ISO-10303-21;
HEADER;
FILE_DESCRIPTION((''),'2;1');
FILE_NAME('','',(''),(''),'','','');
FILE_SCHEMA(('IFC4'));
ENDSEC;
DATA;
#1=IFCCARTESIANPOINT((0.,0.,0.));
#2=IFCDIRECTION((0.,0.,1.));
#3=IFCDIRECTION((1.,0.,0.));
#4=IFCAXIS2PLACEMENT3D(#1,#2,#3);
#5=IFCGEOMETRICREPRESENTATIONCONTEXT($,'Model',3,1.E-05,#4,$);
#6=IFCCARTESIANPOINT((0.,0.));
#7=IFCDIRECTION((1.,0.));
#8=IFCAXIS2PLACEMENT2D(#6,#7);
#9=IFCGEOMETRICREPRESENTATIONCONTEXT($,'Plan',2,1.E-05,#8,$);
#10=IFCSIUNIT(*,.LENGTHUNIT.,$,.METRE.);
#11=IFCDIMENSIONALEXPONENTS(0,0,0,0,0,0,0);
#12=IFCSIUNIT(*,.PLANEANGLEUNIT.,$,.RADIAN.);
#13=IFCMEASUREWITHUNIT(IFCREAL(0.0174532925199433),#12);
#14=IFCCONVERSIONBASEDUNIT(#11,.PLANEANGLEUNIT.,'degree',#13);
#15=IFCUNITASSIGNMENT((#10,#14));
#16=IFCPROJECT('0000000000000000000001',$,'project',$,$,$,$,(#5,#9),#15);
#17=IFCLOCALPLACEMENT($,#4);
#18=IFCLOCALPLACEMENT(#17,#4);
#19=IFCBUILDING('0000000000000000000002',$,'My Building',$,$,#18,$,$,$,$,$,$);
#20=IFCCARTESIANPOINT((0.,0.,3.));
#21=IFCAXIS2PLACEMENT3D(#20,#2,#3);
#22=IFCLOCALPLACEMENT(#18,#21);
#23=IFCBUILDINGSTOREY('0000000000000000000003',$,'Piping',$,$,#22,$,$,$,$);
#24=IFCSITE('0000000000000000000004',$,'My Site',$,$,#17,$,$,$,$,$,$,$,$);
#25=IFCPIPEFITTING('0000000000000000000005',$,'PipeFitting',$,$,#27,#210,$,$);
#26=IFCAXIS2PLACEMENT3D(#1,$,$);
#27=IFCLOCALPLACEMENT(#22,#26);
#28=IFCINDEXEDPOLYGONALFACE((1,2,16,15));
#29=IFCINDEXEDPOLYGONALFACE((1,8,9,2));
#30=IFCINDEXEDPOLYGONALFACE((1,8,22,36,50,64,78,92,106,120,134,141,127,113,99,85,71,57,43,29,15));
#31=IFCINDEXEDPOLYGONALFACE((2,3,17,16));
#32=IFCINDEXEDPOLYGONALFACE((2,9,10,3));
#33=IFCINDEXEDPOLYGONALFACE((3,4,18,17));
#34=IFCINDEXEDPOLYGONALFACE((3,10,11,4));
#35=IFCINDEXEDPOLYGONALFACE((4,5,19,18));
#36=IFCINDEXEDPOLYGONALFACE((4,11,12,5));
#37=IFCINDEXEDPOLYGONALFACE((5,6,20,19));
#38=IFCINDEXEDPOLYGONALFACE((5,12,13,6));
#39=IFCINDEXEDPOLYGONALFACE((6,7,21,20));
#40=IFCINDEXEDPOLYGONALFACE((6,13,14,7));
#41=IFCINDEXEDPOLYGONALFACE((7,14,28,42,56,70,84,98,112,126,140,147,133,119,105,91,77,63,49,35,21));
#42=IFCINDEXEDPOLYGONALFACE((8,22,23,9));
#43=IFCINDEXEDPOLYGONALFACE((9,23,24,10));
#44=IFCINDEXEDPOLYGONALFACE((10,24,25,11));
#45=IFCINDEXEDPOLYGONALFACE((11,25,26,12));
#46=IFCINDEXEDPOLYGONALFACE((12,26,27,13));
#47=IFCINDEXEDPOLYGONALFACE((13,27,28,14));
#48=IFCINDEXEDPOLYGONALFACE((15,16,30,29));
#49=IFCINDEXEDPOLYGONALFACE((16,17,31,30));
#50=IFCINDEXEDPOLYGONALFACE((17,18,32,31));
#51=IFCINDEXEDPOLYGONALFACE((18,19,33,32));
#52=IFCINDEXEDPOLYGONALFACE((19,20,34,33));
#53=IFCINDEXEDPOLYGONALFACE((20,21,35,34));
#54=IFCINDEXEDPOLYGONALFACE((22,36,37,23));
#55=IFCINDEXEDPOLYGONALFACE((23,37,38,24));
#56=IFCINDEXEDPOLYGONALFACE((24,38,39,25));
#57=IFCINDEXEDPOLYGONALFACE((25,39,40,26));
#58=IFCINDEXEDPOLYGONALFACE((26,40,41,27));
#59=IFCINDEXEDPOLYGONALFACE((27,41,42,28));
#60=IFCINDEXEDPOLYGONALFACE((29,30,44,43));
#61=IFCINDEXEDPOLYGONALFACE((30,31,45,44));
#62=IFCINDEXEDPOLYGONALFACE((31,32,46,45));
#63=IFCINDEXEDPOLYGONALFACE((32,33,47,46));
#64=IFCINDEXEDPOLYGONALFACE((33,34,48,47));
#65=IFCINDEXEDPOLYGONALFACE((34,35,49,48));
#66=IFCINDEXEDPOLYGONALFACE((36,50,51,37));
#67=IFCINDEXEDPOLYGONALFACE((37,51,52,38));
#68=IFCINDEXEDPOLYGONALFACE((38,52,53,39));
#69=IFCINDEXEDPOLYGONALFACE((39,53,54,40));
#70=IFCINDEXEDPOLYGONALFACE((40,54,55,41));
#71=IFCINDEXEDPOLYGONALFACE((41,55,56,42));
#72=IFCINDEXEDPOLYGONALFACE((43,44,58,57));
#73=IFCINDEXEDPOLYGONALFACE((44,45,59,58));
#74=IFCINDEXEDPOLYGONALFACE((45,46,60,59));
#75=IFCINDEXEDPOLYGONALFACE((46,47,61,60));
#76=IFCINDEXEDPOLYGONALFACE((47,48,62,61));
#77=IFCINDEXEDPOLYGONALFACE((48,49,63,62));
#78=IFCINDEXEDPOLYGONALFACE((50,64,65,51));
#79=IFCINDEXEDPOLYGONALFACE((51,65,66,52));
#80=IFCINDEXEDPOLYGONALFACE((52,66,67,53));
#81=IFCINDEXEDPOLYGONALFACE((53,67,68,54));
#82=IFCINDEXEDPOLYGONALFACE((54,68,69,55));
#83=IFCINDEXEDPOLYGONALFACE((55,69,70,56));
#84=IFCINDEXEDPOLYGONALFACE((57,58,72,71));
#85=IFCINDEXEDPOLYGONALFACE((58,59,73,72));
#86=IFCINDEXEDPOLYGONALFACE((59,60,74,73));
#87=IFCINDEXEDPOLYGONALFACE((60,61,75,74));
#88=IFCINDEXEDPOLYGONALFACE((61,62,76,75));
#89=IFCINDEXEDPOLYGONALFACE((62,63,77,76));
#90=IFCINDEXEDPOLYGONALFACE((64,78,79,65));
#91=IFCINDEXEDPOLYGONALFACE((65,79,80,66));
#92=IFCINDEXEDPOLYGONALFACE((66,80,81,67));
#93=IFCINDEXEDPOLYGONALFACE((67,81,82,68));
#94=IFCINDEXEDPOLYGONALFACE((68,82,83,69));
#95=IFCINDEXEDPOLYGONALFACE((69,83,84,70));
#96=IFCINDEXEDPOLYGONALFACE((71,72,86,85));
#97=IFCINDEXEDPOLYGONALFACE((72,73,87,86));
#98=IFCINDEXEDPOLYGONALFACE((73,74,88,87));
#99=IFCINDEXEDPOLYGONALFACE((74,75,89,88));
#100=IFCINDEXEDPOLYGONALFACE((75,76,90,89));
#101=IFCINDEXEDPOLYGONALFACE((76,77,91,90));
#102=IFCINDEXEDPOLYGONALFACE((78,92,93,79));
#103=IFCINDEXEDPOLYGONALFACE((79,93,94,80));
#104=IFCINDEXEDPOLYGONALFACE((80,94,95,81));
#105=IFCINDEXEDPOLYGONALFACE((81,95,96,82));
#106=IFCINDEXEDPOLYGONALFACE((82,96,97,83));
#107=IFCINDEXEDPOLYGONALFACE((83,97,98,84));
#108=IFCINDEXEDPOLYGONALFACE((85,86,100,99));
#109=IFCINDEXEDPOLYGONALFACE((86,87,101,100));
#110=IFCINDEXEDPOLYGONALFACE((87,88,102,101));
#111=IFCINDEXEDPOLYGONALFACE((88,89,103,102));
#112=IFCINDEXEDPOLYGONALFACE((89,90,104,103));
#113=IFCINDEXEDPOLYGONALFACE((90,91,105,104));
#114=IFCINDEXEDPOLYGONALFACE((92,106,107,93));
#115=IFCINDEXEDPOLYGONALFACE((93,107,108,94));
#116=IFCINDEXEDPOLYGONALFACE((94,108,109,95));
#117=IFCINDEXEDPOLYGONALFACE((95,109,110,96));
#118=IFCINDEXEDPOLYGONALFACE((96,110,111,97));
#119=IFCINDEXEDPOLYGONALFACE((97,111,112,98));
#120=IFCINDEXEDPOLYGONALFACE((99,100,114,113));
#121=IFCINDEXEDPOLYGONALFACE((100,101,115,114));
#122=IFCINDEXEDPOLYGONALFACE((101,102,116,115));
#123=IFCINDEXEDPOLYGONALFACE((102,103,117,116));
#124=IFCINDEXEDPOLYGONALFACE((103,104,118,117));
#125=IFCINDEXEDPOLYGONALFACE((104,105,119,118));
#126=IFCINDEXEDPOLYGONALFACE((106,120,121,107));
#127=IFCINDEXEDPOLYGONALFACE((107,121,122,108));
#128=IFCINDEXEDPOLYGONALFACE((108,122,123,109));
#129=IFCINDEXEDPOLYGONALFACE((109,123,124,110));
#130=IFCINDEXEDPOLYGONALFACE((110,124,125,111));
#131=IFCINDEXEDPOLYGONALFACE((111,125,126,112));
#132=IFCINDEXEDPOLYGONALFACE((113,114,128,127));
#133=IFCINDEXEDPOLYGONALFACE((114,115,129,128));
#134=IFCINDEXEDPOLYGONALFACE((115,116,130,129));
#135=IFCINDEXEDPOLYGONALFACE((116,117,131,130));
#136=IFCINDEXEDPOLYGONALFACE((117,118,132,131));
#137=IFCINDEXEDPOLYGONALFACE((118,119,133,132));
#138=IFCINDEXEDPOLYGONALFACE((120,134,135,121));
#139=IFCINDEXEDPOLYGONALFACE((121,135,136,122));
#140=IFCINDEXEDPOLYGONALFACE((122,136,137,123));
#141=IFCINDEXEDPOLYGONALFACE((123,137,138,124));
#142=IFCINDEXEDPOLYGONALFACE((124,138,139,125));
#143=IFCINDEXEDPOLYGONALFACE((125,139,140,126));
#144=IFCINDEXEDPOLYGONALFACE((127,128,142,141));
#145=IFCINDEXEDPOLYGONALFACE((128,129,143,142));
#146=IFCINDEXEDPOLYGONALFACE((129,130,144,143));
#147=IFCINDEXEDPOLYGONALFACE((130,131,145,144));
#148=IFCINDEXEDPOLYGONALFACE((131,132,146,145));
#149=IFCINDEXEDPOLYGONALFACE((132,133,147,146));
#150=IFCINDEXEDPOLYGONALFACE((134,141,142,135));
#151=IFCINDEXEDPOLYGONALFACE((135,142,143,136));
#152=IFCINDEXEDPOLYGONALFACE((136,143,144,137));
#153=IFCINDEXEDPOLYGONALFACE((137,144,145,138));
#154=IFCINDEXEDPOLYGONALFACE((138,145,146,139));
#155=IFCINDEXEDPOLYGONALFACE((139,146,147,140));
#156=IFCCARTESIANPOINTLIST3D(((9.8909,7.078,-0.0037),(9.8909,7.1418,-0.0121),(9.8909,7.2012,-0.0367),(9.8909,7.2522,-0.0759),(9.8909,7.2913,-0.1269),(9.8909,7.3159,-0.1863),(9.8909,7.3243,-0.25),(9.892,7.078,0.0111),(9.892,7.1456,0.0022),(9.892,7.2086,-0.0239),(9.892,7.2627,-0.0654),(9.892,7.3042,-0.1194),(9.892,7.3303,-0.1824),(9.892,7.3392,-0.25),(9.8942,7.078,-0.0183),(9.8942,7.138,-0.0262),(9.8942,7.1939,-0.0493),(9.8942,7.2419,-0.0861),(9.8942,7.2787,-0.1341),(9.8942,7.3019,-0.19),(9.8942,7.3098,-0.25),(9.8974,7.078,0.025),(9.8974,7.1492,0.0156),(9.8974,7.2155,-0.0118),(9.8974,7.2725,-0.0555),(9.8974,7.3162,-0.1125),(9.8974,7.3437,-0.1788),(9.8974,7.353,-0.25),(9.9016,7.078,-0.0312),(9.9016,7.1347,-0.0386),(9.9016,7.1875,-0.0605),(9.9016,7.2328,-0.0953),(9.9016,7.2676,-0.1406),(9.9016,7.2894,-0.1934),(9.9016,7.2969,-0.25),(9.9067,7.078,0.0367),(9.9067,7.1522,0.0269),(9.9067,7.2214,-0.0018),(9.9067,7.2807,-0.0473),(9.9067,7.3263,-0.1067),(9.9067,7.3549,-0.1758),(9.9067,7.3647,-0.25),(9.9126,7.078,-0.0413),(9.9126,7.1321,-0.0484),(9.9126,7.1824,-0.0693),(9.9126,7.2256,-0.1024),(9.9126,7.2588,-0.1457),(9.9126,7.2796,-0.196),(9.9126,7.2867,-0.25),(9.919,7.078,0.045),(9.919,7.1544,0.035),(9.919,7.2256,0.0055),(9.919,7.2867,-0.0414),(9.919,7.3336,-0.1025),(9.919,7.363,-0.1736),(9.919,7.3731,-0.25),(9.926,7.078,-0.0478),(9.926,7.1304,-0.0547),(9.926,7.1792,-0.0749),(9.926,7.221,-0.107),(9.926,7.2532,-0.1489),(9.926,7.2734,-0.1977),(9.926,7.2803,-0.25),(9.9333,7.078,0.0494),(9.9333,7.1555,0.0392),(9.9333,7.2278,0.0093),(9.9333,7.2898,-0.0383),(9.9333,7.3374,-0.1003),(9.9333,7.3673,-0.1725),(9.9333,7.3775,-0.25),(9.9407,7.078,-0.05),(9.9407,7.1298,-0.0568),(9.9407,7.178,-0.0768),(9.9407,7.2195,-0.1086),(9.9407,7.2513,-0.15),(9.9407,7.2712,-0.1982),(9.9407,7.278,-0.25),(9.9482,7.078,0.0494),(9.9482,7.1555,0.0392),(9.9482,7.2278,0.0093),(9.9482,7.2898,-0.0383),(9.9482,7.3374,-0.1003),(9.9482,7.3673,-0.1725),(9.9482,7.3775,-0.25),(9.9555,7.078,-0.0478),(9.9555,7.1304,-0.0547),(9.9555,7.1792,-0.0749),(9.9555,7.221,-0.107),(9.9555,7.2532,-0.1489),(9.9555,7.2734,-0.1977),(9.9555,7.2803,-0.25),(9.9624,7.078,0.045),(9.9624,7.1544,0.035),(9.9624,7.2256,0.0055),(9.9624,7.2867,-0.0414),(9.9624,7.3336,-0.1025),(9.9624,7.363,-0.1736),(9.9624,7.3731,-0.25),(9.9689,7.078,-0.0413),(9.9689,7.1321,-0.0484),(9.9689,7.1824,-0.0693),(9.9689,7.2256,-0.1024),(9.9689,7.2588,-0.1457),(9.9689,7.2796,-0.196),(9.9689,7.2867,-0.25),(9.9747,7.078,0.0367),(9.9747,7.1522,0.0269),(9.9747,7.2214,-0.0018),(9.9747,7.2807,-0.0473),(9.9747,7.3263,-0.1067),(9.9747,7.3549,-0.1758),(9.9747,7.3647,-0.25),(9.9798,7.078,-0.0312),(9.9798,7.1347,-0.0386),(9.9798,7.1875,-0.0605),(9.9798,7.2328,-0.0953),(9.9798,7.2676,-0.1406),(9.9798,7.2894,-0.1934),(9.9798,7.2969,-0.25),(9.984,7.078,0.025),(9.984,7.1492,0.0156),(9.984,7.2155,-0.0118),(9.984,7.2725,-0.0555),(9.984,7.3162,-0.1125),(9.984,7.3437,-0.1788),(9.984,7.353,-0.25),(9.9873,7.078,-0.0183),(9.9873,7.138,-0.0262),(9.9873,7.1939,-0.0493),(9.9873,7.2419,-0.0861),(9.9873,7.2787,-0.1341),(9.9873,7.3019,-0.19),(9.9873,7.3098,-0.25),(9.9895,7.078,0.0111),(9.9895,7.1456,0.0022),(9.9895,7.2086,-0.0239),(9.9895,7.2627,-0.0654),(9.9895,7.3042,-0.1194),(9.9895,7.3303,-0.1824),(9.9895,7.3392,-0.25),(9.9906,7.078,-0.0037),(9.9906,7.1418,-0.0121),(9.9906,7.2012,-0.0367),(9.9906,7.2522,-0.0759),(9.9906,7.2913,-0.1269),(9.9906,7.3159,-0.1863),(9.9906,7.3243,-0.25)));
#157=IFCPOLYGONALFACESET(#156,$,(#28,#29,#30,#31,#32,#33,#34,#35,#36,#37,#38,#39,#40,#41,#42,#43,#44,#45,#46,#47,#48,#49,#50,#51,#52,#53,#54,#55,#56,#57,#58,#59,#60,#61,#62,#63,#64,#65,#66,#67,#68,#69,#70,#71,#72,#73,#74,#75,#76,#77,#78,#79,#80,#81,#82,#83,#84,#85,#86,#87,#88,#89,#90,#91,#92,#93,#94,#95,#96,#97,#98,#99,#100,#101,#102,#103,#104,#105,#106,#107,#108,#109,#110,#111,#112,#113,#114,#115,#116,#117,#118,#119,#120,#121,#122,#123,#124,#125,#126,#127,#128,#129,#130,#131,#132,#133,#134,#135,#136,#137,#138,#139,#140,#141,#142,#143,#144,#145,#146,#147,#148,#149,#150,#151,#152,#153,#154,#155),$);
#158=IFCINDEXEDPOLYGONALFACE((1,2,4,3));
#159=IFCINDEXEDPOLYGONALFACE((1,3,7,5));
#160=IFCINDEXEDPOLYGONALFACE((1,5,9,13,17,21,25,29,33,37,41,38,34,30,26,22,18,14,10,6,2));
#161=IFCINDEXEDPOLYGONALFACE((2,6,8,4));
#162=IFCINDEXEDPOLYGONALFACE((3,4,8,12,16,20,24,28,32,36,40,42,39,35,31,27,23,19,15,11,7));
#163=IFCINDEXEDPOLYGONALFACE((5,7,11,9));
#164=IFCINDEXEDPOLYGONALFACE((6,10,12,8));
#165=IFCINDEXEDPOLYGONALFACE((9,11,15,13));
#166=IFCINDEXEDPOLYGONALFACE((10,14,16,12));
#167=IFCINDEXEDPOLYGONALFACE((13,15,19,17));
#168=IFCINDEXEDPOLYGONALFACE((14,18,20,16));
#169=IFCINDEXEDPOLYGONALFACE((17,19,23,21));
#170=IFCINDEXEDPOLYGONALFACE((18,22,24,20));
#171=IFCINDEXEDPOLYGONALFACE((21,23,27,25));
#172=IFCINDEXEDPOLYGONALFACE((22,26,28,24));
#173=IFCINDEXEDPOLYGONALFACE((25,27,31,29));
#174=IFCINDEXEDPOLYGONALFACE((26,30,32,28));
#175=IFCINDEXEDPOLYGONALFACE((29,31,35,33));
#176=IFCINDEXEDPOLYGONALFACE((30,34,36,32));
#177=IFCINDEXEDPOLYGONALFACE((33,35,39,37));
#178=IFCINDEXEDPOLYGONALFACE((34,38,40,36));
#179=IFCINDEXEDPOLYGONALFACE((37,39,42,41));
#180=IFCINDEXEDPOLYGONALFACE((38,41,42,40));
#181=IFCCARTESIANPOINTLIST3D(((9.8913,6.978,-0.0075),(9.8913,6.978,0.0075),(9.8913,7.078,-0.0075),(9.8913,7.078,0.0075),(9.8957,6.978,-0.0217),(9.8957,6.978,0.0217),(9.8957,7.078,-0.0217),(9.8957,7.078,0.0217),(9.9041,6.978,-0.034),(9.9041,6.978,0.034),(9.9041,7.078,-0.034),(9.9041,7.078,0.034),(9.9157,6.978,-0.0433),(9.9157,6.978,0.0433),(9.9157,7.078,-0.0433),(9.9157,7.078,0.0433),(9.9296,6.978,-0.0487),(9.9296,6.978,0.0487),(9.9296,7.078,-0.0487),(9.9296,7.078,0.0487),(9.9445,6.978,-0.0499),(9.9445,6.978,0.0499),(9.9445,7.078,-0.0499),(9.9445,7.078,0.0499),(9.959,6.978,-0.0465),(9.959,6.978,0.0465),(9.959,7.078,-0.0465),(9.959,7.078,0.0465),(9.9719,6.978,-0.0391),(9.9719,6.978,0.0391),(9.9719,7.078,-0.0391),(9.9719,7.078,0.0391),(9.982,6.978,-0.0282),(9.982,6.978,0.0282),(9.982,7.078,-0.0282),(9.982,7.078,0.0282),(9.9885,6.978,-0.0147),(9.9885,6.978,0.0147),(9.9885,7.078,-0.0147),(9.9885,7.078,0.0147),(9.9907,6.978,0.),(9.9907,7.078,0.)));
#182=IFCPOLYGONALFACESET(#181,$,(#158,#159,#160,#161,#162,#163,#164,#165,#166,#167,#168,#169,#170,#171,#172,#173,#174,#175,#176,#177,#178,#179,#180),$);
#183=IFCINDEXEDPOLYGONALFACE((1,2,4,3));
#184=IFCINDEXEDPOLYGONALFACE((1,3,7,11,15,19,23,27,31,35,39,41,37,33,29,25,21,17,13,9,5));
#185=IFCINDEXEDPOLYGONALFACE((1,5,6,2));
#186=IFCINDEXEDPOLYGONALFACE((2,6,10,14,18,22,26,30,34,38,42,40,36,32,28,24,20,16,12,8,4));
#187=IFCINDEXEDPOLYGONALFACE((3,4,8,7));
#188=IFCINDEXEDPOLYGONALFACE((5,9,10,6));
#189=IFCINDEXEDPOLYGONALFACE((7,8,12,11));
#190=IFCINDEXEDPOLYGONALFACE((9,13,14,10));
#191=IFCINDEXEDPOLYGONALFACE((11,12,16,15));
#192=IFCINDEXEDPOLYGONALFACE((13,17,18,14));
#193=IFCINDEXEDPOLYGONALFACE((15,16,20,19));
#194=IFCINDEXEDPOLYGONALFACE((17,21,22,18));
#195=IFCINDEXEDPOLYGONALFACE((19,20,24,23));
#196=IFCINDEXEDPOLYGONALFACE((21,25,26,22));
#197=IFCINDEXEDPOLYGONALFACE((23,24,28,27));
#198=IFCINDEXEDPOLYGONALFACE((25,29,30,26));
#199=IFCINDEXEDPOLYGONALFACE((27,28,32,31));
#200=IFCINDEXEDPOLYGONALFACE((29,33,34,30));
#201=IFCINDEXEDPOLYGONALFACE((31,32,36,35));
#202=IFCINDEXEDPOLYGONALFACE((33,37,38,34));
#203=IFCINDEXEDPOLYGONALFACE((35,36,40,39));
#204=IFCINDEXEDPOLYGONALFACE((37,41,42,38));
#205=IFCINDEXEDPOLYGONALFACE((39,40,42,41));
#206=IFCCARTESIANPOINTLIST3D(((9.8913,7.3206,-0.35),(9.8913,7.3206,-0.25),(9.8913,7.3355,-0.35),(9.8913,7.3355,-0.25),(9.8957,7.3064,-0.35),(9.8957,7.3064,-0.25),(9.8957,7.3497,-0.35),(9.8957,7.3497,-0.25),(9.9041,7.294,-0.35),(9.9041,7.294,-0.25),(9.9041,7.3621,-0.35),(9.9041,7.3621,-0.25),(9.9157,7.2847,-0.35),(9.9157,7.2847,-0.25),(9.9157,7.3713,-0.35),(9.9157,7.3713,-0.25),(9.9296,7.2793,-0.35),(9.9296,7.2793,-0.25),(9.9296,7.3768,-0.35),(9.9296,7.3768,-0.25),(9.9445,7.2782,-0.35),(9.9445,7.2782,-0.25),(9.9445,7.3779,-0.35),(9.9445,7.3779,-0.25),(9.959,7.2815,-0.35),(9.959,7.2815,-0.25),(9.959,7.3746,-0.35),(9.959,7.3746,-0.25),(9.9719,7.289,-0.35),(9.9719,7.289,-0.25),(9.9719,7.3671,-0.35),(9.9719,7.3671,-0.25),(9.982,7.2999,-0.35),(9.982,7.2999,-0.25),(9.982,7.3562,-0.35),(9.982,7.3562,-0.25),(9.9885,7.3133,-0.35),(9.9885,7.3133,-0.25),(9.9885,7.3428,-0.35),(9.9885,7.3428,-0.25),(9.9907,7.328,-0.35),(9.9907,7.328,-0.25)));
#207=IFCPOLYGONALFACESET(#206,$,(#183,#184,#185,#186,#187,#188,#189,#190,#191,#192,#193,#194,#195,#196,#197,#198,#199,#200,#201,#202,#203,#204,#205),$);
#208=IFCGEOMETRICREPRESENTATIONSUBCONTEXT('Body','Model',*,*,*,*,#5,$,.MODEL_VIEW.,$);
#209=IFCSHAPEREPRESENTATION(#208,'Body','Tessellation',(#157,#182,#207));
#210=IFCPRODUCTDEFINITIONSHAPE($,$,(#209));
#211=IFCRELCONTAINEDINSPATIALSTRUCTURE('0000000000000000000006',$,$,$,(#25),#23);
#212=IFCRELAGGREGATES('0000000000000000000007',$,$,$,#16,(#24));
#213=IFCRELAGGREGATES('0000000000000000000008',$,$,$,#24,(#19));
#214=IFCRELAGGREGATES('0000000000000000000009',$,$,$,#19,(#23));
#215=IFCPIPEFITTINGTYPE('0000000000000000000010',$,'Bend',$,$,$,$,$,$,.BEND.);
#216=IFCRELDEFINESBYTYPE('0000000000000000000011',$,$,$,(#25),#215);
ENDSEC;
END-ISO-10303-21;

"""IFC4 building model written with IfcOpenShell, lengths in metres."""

from ifc_helpers import new_model, entity, si_unit, converted_unit, frame, origin_with_axes, origin_2d_with_axis, place, context, subcontext, project, spatial, circle, extrude, source, transform, mapped, type_object, type_shapes, element, save


model = new_model("IFC4")

# Units and contexts
model_context = context("Model", 3, precision=1e-05, world=origin_with_axes())
plan_context = context("Plan", 2, precision=1e-05, world=origin_2d_with_axis())
body_context = subcontext(model_context, "Body", "Model", "MODEL_VIEW")
ifc_project = project(units=[si_unit("LENGTHUNIT", "METRE"), converted_unit("PLANEANGLEUNIT", "degree", entity("IfcReal", 0.0174532925199433), si_unit("PLANEANGLEUNIT", "RADIAN"), dimensions=[0, 0, 0, 0, 0, 0, 0])], contexts=[model_context, plan_context])

# Site, building, storey
site_placement = place(None, origin_with_axes())
site = spatial("IfcSite", under=ifc_project, at=site_placement, Name="My Site")
building_placement = place(site_placement, origin_with_axes())
building = spatial("IfcBuilding", under=site, at=building_placement, Name="My Building")
storey_placement = place(building_placement, frame((0.0, 0.0, 3.0), z_axis=(0.0, 0.0, 1.0), x_axis=(1.0, 0.0, 0.0)))
storey = spatial("IfcBuildingStorey", under=building, at=storey_placement, Name="Piping")

# Pipe fitting
pipe_fitting_type_1 = type_object("IfcPipeFittingType", Name="Bend", PredefinedType="BEND")
shared_shape = source(origin_with_axes(), body_context, "Body", "SolidModel", [
    entity("IfcSweptDiskSolid", entity("IfcIndexedPolyCurve", entity("IfcCartesianPointList3D", [[0.0, 0.0, -0.1], [0.0, -0.0732, -0.2768], [0.0, -0.25, -0.35]]), [entity("IfcArcIndex", [1, 2, 3])]), 0.05),
    extrude(circle(Radius=0.05), origin_with_axes(), (0.0, 0.0, -1.0), 0.1),
    extrude(circle(Radius=0.05), frame((0.0, -0.25, -0.35), z_axis=(0.0, -1.0, 0.0), x_axis=(1.0, 0.0, 0.0)), (0.0, 0.0, 1.0), 0.1),
])
type_shapes(pipe_fitting_type_1, [shared_shape])
for number, where, z_axis, x_axis, name in (
    (1, (9.9407, 6.978, 0.0), (0.0, -1.0, 0.0), (1.0, 0.0, 0.0), "PipeFitting"),
):
    element("IfcPipeFitting", number, at=place(storey_placement, frame(where, z_axis=z_axis, x_axis=x_axis)), inside=storey, type_object=pipe_fitting_type_1, Name=name, context=body_context, shape_type="MappedRepresentation", body=[
        mapped(shared_shape, transform((0.0, 0.0, 0.0), x_axis=(1.0, 0.0, 0.0), y_axis=(0.0, 1.0, 0.0), z_axis=(0.0, 0.0, 1.0), scale=1.0)),
    ])

save(model, "model.ifc")
